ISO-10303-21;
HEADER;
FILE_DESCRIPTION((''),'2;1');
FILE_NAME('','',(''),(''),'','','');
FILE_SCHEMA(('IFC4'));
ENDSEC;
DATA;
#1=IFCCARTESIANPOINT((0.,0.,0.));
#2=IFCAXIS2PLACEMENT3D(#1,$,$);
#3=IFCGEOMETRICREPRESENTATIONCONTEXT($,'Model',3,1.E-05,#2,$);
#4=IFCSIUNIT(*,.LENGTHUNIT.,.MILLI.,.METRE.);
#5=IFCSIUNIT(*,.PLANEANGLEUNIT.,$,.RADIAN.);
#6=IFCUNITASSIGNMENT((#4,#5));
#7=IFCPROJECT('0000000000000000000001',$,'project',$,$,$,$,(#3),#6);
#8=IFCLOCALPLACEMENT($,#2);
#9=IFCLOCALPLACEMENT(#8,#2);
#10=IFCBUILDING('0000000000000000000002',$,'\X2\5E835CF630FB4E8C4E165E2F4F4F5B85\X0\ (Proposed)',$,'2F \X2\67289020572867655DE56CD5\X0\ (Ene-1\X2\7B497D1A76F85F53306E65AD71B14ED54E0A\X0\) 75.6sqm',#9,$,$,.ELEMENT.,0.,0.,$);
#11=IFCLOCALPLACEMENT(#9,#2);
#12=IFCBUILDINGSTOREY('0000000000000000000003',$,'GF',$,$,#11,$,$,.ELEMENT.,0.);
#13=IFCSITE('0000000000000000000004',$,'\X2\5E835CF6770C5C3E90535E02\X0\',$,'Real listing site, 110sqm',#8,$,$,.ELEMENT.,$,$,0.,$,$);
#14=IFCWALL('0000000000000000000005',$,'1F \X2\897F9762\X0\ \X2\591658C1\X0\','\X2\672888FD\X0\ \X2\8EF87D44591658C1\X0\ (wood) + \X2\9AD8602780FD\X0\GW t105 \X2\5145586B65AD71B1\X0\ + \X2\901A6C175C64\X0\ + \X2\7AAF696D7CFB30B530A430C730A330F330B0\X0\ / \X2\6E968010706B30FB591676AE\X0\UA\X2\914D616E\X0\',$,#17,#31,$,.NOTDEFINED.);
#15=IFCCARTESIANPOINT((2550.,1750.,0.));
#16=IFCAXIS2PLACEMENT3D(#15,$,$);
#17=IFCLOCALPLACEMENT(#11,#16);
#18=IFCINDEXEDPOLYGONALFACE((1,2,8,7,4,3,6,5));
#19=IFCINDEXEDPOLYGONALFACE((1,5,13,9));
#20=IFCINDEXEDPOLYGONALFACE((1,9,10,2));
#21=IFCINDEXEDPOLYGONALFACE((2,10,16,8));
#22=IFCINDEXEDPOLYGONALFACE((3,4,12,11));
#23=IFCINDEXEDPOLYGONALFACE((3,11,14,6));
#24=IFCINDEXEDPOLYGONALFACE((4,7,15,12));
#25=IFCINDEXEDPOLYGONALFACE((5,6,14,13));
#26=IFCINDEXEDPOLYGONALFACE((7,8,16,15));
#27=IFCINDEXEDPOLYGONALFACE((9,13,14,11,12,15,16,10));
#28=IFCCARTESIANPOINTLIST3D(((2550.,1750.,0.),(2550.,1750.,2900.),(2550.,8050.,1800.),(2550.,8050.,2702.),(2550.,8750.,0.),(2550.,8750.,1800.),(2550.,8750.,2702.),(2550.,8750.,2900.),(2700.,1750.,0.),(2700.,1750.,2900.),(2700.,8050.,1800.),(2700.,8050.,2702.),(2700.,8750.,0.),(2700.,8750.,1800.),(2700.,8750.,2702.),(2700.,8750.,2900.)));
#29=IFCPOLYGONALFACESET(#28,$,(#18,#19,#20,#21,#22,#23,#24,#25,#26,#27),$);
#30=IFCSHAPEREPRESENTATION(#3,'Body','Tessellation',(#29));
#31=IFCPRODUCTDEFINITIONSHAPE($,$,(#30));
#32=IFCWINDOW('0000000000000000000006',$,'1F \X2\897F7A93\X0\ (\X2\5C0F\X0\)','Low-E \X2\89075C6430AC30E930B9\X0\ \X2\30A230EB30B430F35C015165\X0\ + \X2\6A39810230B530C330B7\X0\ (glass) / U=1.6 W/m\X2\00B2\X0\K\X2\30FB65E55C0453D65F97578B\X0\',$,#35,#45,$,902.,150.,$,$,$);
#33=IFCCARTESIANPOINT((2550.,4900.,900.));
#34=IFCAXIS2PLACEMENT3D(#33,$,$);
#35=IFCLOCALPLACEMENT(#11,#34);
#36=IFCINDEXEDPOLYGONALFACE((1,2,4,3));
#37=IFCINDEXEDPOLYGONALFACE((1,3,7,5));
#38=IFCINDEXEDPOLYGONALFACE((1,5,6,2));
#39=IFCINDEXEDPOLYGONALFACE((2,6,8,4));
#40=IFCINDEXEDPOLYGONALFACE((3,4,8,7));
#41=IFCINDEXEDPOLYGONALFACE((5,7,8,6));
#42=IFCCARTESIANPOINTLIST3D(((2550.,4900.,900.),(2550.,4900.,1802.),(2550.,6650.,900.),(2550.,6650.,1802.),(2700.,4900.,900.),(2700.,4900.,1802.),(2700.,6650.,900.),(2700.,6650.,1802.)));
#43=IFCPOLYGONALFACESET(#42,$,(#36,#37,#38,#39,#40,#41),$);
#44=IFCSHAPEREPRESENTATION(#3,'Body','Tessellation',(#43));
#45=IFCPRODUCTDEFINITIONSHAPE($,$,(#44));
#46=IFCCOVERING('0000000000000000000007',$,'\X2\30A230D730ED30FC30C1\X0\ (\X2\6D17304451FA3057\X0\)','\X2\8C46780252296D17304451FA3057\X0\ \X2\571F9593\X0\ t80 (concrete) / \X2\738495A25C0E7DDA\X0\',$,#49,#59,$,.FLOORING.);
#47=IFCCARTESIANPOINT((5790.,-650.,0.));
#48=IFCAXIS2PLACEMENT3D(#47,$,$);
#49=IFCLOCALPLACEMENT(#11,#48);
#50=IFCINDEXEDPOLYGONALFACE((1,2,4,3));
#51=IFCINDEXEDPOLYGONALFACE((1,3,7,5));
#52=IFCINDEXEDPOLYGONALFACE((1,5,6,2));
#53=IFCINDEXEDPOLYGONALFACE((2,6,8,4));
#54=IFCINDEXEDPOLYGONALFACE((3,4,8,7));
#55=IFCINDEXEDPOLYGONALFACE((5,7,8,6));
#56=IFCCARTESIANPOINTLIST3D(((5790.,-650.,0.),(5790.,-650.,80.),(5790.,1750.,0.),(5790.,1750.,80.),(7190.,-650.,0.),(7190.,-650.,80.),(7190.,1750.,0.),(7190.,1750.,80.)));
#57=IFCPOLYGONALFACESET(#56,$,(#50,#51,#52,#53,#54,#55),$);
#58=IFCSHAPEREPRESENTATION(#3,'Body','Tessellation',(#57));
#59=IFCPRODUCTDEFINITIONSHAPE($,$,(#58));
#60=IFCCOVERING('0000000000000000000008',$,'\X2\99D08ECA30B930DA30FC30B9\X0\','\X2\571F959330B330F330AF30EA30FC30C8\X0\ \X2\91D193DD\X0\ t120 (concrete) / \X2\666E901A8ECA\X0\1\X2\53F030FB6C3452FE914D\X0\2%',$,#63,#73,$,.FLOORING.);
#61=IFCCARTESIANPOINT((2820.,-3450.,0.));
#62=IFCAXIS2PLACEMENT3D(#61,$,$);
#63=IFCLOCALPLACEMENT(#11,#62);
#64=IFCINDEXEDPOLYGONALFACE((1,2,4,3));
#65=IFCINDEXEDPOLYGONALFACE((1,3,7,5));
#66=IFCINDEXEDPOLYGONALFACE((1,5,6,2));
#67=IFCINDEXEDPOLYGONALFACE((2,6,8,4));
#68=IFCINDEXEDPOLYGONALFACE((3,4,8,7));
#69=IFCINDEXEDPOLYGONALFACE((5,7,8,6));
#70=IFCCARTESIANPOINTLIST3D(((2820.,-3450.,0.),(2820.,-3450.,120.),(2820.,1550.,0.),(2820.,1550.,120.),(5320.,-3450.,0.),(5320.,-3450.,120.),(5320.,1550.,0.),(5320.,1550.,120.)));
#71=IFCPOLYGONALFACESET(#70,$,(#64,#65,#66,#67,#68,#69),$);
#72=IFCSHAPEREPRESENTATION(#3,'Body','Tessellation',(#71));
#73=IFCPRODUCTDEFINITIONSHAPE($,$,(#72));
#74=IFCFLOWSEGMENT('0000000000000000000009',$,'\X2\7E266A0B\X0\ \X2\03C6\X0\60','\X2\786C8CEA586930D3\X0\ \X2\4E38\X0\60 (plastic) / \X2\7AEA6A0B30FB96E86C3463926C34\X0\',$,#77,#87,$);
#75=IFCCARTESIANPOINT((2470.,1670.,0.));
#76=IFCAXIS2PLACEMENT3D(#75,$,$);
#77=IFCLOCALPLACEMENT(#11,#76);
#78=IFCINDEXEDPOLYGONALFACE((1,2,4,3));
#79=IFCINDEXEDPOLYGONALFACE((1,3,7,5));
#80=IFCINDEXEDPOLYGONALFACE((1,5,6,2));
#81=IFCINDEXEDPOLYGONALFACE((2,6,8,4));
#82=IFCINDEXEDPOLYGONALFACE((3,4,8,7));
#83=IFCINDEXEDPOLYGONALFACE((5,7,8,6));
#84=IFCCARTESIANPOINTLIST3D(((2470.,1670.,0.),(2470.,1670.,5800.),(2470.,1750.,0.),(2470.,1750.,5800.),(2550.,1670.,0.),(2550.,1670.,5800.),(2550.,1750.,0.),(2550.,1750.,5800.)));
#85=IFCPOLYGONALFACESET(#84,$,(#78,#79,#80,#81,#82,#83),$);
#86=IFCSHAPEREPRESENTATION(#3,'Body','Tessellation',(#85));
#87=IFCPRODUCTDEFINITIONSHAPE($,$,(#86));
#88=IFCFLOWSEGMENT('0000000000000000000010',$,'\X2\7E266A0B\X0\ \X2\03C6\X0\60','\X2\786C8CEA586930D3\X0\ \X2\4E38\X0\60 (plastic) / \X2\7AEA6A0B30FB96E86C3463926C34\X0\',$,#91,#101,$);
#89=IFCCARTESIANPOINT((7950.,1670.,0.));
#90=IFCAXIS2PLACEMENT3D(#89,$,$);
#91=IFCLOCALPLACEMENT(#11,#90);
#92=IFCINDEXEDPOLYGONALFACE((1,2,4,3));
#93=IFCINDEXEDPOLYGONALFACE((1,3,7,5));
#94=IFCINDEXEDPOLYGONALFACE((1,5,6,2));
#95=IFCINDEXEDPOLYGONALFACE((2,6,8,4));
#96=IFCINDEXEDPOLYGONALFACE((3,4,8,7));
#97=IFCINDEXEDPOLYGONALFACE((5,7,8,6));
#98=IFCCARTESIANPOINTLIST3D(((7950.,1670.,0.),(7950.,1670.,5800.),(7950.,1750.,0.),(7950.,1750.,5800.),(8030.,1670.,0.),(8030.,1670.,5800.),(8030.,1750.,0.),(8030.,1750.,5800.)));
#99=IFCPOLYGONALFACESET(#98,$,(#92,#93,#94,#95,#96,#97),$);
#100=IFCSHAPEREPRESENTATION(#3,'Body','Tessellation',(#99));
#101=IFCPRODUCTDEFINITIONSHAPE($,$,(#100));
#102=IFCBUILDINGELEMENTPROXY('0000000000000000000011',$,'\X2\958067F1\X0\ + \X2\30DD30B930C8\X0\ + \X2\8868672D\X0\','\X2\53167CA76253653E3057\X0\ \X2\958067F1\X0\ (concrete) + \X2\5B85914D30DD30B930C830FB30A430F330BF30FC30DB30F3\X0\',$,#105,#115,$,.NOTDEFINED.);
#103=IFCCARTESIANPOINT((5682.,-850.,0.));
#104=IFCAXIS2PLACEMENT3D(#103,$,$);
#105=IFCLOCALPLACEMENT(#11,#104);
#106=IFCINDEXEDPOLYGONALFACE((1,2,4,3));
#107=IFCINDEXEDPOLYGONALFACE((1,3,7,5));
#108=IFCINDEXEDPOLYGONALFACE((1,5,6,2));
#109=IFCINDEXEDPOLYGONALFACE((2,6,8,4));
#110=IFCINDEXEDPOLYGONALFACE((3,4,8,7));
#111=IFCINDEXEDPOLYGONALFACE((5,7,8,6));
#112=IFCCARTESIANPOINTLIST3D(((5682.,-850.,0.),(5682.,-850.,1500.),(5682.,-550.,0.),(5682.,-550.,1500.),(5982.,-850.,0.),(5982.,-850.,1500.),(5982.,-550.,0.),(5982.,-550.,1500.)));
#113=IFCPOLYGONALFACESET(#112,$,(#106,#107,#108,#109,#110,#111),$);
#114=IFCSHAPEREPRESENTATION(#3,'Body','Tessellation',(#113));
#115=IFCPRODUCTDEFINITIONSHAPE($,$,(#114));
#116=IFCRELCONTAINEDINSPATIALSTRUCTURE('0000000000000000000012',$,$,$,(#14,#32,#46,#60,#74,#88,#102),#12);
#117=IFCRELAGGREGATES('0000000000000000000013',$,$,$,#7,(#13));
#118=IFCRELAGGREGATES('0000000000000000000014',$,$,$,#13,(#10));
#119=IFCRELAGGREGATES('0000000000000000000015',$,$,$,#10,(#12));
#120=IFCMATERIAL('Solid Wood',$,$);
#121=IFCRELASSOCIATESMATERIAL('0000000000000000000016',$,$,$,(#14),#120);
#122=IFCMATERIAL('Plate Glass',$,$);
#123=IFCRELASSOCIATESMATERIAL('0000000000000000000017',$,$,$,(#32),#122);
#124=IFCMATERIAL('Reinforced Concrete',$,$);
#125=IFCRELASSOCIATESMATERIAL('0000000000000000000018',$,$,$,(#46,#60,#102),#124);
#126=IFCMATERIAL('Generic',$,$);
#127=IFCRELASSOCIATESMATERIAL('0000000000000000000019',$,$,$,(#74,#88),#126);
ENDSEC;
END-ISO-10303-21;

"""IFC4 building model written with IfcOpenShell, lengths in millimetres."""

from ifc_helpers import new_model, si_unit, frame, frame_2d, origin, place, context, project, spatial, rectangle, extrude, material, element, fill, save


model = new_model("IFC4")

# Units and contexts
model_context = context("Model", 3, precision=1e-05, world=origin())
ifc_project = project(units=[si_unit("LENGTHUNIT", "METRE", prefix="MILLI"), si_unit("PLANEANGLEUNIT", "RADIAN")], contexts=[model_context])

# Site, building, storey
site_placement = place(None, origin())
site = spatial("IfcSite", under=ifc_project, at=site_placement, Name="広島県尾道市", ObjectType="Real listing site, 110sqm", CompositionType="ELEMENT", RefElevation=0.0)
building_placement = place(site_placement, origin())
building = spatial("IfcBuilding", under=site, at=building_placement, Name="広島・二世帯住宅 (Proposed)", ObjectType="2F 木造在来工法 (Ene-1等級相当の断熱仕上) 75.6sqm", CompositionType="ELEMENT", ElevationOfRefHeight=0.0, ElevationOfTerrain=0.0)
storey_placement = place(building_placement, origin())
storey = spatial("IfcBuildingStorey", under=building, at=storey_placement, Name="GF", CompositionType="ELEMENT", Elevation=0.0)

# Shared definitions
ifc_material_1 = material(Name="Solid Wood")

# Shared definitions
ifc_material_2 = material(Name="Reinforced Concrete")

# Shared definitions
ifc_material_3 = material(Name="Plate Glass")

# Wall, opening, window
wall_1_placement = place(storey_placement, frame((2550.0, 1750.0, 0.0)))
wall_1 = element("IfcWall", 1, at=wall_1_placement, inside=storey, material=ifc_material_1, Name="1F 西面 外壁", Description="木製 軸組外壁 (wood) + 高性能GW t105 充填断熱 + 通気層 + 窯業系サイディング / 準耐火・外皮UA配慮", PredefinedType="NOTDEFINED", context=model_context, shape_type="SweptSolid", body=[
    extrude(rectangle(XDim=150.0, YDim=7000.0, at=frame_2d((75.0, 3500.0))), frame((2550.0, 1750.0, 0.0)), (0.0, 0.0, 1.0), 2900.0),
])
opening_1_placement = place(storey_placement, frame((2550.0, 4900.0, 900.0)))
opening_1 = element("IfcOpeningElement", 2, at=opening_1_placement, cuts=wall_1, PredefinedType="NOTDEFINED", context=model_context, shape_type="SweptSolid", body=[
    extrude(rectangle(XDim=150.0, YDim=1750.0, at=frame_2d((75.0, 875.0))), frame((2550.0, 4900.0, 900.0)), (0.0, 0.0, 1.0), 902.0),
])
window_1_placement = place(storey_placement, frame((2550.0, 4900.0, 900.0)))
window_1 = element("IfcWindow", 3, at=window_1_placement, inside=storey, material=ifc_material_3, Name="1F 西窓 (小)", Description="Low-E 複層ガラス アルゴン封入 + 樹脂サッシ (glass) / U=1.6 W/m²K・日射取得型", OverallHeight=902.0, OverallWidth=150.0, context=model_context, shape_type="SweptSolid", body=[
    extrude(rectangle(XDim=150.0, YDim=1750.0, at=frame_2d((75.0, 875.0))), frame((2550.0, 4900.0, 900.0)), (0.0, 0.0, 1.0), 902.0),
])
fill(opening_1, window_1)

# Coverings
covering_1_placement = place(storey_placement, frame((5790.0, -650.0, 0.0)))
element("IfcCovering", 4, at=covering_1_placement, inside=storey, material=ifc_material_2, Name="アプローチ (洗い出し)", Description="豆砂利洗い出し 土間 t80 (concrete) / 玄関導線", PredefinedType="FLOORING", context=model_context, shape_type="SweptSolid", body=[
    extrude(rectangle(XDim=1400.0, YDim=2400.0, at=frame_2d((700.0, 1200.0))), frame((5790.0, -650.0, 0.0)), (0.0, 0.0, 1.0), 80.0),
])
covering_2_placement = place(storey_placement, frame((2820.0, -3450.0, 0.0)))
element("IfcCovering", 5, at=covering_2_placement, inside=storey, material=ifc_material_2, Name="駐車スペース", Description="土間コンクリート 金鏝 t120 (concrete) / 普通車1台・水勾配2%", PredefinedType="FLOORING", context=model_context, shape_type="SweptSolid", body=[
    extrude(rectangle(XDim=2500.0, YDim=5000.0, at=frame_2d((1250.0, 2500.0))), frame((2820.0, -3450.0, 0.0)), (0.0, 0.0, 1.0), 120.0),
])

# Flow segments
ifc_material_4 = material(Name="Generic")
flow_segment_1_placement = place(storey_placement, frame((2470.0, 1670.0, 0.0)))
element("IfcFlowSegment", 6, at=flow_segment_1_placement, inside=storey, material=ifc_material_4, Name="縦樋 φ60", Description="硬質塩ビ 丸60 (plastic) / 竪樋・雨水排水", context=model_context, shape_type="SweptSolid", body=[
    extrude(rectangle(XDim=80.0, YDim=80.0, at=frame_2d((40.0, 40.0))), frame((2470.0, 1670.0, 0.0)), (0.0, 0.0, 1.0), 5800.0),
])
flow_segment_2_placement = place(storey_placement, frame((7950.0, 1670.0, 0.0)))
element("IfcFlowSegment", 7, at=flow_segment_2_placement, inside=storey, material=ifc_material_4, Name="縦樋 φ60", Description="硬質塩ビ 丸60 (plastic) / 竪樋・雨水排水", context=model_context, shape_type="SweptSolid", body=[
    extrude(rectangle(XDim=80.0, YDim=80.0, at=frame_2d((40.0, 40.0))), frame((7950.0, 1670.0, 0.0)), (0.0, 0.0, 1.0), 5800.0),
])

# Building element proxy
proxy_placement = place(storey_placement, frame((5682.0, -850.0, 0.0)))
element("IfcBuildingElementProxy", 8, at=proxy_placement, inside=storey, material=ifc_material_2, Name="門柱 + ポスト + 表札", Description="化粧打放し 門柱 (concrete) + 宅配ポスト・インターホン", PredefinedType="NOTDEFINED", context=model_context, shape_type="SweptSolid", body=[
    extrude(rectangle(XDim=300.0, YDim=300.0, at=frame_2d((150.0, 150.0))), frame((5682.0, -850.0, 0.0)), (0.0, 0.0, 1.0), 1500.0),
])

save(model, "model.ifc")
